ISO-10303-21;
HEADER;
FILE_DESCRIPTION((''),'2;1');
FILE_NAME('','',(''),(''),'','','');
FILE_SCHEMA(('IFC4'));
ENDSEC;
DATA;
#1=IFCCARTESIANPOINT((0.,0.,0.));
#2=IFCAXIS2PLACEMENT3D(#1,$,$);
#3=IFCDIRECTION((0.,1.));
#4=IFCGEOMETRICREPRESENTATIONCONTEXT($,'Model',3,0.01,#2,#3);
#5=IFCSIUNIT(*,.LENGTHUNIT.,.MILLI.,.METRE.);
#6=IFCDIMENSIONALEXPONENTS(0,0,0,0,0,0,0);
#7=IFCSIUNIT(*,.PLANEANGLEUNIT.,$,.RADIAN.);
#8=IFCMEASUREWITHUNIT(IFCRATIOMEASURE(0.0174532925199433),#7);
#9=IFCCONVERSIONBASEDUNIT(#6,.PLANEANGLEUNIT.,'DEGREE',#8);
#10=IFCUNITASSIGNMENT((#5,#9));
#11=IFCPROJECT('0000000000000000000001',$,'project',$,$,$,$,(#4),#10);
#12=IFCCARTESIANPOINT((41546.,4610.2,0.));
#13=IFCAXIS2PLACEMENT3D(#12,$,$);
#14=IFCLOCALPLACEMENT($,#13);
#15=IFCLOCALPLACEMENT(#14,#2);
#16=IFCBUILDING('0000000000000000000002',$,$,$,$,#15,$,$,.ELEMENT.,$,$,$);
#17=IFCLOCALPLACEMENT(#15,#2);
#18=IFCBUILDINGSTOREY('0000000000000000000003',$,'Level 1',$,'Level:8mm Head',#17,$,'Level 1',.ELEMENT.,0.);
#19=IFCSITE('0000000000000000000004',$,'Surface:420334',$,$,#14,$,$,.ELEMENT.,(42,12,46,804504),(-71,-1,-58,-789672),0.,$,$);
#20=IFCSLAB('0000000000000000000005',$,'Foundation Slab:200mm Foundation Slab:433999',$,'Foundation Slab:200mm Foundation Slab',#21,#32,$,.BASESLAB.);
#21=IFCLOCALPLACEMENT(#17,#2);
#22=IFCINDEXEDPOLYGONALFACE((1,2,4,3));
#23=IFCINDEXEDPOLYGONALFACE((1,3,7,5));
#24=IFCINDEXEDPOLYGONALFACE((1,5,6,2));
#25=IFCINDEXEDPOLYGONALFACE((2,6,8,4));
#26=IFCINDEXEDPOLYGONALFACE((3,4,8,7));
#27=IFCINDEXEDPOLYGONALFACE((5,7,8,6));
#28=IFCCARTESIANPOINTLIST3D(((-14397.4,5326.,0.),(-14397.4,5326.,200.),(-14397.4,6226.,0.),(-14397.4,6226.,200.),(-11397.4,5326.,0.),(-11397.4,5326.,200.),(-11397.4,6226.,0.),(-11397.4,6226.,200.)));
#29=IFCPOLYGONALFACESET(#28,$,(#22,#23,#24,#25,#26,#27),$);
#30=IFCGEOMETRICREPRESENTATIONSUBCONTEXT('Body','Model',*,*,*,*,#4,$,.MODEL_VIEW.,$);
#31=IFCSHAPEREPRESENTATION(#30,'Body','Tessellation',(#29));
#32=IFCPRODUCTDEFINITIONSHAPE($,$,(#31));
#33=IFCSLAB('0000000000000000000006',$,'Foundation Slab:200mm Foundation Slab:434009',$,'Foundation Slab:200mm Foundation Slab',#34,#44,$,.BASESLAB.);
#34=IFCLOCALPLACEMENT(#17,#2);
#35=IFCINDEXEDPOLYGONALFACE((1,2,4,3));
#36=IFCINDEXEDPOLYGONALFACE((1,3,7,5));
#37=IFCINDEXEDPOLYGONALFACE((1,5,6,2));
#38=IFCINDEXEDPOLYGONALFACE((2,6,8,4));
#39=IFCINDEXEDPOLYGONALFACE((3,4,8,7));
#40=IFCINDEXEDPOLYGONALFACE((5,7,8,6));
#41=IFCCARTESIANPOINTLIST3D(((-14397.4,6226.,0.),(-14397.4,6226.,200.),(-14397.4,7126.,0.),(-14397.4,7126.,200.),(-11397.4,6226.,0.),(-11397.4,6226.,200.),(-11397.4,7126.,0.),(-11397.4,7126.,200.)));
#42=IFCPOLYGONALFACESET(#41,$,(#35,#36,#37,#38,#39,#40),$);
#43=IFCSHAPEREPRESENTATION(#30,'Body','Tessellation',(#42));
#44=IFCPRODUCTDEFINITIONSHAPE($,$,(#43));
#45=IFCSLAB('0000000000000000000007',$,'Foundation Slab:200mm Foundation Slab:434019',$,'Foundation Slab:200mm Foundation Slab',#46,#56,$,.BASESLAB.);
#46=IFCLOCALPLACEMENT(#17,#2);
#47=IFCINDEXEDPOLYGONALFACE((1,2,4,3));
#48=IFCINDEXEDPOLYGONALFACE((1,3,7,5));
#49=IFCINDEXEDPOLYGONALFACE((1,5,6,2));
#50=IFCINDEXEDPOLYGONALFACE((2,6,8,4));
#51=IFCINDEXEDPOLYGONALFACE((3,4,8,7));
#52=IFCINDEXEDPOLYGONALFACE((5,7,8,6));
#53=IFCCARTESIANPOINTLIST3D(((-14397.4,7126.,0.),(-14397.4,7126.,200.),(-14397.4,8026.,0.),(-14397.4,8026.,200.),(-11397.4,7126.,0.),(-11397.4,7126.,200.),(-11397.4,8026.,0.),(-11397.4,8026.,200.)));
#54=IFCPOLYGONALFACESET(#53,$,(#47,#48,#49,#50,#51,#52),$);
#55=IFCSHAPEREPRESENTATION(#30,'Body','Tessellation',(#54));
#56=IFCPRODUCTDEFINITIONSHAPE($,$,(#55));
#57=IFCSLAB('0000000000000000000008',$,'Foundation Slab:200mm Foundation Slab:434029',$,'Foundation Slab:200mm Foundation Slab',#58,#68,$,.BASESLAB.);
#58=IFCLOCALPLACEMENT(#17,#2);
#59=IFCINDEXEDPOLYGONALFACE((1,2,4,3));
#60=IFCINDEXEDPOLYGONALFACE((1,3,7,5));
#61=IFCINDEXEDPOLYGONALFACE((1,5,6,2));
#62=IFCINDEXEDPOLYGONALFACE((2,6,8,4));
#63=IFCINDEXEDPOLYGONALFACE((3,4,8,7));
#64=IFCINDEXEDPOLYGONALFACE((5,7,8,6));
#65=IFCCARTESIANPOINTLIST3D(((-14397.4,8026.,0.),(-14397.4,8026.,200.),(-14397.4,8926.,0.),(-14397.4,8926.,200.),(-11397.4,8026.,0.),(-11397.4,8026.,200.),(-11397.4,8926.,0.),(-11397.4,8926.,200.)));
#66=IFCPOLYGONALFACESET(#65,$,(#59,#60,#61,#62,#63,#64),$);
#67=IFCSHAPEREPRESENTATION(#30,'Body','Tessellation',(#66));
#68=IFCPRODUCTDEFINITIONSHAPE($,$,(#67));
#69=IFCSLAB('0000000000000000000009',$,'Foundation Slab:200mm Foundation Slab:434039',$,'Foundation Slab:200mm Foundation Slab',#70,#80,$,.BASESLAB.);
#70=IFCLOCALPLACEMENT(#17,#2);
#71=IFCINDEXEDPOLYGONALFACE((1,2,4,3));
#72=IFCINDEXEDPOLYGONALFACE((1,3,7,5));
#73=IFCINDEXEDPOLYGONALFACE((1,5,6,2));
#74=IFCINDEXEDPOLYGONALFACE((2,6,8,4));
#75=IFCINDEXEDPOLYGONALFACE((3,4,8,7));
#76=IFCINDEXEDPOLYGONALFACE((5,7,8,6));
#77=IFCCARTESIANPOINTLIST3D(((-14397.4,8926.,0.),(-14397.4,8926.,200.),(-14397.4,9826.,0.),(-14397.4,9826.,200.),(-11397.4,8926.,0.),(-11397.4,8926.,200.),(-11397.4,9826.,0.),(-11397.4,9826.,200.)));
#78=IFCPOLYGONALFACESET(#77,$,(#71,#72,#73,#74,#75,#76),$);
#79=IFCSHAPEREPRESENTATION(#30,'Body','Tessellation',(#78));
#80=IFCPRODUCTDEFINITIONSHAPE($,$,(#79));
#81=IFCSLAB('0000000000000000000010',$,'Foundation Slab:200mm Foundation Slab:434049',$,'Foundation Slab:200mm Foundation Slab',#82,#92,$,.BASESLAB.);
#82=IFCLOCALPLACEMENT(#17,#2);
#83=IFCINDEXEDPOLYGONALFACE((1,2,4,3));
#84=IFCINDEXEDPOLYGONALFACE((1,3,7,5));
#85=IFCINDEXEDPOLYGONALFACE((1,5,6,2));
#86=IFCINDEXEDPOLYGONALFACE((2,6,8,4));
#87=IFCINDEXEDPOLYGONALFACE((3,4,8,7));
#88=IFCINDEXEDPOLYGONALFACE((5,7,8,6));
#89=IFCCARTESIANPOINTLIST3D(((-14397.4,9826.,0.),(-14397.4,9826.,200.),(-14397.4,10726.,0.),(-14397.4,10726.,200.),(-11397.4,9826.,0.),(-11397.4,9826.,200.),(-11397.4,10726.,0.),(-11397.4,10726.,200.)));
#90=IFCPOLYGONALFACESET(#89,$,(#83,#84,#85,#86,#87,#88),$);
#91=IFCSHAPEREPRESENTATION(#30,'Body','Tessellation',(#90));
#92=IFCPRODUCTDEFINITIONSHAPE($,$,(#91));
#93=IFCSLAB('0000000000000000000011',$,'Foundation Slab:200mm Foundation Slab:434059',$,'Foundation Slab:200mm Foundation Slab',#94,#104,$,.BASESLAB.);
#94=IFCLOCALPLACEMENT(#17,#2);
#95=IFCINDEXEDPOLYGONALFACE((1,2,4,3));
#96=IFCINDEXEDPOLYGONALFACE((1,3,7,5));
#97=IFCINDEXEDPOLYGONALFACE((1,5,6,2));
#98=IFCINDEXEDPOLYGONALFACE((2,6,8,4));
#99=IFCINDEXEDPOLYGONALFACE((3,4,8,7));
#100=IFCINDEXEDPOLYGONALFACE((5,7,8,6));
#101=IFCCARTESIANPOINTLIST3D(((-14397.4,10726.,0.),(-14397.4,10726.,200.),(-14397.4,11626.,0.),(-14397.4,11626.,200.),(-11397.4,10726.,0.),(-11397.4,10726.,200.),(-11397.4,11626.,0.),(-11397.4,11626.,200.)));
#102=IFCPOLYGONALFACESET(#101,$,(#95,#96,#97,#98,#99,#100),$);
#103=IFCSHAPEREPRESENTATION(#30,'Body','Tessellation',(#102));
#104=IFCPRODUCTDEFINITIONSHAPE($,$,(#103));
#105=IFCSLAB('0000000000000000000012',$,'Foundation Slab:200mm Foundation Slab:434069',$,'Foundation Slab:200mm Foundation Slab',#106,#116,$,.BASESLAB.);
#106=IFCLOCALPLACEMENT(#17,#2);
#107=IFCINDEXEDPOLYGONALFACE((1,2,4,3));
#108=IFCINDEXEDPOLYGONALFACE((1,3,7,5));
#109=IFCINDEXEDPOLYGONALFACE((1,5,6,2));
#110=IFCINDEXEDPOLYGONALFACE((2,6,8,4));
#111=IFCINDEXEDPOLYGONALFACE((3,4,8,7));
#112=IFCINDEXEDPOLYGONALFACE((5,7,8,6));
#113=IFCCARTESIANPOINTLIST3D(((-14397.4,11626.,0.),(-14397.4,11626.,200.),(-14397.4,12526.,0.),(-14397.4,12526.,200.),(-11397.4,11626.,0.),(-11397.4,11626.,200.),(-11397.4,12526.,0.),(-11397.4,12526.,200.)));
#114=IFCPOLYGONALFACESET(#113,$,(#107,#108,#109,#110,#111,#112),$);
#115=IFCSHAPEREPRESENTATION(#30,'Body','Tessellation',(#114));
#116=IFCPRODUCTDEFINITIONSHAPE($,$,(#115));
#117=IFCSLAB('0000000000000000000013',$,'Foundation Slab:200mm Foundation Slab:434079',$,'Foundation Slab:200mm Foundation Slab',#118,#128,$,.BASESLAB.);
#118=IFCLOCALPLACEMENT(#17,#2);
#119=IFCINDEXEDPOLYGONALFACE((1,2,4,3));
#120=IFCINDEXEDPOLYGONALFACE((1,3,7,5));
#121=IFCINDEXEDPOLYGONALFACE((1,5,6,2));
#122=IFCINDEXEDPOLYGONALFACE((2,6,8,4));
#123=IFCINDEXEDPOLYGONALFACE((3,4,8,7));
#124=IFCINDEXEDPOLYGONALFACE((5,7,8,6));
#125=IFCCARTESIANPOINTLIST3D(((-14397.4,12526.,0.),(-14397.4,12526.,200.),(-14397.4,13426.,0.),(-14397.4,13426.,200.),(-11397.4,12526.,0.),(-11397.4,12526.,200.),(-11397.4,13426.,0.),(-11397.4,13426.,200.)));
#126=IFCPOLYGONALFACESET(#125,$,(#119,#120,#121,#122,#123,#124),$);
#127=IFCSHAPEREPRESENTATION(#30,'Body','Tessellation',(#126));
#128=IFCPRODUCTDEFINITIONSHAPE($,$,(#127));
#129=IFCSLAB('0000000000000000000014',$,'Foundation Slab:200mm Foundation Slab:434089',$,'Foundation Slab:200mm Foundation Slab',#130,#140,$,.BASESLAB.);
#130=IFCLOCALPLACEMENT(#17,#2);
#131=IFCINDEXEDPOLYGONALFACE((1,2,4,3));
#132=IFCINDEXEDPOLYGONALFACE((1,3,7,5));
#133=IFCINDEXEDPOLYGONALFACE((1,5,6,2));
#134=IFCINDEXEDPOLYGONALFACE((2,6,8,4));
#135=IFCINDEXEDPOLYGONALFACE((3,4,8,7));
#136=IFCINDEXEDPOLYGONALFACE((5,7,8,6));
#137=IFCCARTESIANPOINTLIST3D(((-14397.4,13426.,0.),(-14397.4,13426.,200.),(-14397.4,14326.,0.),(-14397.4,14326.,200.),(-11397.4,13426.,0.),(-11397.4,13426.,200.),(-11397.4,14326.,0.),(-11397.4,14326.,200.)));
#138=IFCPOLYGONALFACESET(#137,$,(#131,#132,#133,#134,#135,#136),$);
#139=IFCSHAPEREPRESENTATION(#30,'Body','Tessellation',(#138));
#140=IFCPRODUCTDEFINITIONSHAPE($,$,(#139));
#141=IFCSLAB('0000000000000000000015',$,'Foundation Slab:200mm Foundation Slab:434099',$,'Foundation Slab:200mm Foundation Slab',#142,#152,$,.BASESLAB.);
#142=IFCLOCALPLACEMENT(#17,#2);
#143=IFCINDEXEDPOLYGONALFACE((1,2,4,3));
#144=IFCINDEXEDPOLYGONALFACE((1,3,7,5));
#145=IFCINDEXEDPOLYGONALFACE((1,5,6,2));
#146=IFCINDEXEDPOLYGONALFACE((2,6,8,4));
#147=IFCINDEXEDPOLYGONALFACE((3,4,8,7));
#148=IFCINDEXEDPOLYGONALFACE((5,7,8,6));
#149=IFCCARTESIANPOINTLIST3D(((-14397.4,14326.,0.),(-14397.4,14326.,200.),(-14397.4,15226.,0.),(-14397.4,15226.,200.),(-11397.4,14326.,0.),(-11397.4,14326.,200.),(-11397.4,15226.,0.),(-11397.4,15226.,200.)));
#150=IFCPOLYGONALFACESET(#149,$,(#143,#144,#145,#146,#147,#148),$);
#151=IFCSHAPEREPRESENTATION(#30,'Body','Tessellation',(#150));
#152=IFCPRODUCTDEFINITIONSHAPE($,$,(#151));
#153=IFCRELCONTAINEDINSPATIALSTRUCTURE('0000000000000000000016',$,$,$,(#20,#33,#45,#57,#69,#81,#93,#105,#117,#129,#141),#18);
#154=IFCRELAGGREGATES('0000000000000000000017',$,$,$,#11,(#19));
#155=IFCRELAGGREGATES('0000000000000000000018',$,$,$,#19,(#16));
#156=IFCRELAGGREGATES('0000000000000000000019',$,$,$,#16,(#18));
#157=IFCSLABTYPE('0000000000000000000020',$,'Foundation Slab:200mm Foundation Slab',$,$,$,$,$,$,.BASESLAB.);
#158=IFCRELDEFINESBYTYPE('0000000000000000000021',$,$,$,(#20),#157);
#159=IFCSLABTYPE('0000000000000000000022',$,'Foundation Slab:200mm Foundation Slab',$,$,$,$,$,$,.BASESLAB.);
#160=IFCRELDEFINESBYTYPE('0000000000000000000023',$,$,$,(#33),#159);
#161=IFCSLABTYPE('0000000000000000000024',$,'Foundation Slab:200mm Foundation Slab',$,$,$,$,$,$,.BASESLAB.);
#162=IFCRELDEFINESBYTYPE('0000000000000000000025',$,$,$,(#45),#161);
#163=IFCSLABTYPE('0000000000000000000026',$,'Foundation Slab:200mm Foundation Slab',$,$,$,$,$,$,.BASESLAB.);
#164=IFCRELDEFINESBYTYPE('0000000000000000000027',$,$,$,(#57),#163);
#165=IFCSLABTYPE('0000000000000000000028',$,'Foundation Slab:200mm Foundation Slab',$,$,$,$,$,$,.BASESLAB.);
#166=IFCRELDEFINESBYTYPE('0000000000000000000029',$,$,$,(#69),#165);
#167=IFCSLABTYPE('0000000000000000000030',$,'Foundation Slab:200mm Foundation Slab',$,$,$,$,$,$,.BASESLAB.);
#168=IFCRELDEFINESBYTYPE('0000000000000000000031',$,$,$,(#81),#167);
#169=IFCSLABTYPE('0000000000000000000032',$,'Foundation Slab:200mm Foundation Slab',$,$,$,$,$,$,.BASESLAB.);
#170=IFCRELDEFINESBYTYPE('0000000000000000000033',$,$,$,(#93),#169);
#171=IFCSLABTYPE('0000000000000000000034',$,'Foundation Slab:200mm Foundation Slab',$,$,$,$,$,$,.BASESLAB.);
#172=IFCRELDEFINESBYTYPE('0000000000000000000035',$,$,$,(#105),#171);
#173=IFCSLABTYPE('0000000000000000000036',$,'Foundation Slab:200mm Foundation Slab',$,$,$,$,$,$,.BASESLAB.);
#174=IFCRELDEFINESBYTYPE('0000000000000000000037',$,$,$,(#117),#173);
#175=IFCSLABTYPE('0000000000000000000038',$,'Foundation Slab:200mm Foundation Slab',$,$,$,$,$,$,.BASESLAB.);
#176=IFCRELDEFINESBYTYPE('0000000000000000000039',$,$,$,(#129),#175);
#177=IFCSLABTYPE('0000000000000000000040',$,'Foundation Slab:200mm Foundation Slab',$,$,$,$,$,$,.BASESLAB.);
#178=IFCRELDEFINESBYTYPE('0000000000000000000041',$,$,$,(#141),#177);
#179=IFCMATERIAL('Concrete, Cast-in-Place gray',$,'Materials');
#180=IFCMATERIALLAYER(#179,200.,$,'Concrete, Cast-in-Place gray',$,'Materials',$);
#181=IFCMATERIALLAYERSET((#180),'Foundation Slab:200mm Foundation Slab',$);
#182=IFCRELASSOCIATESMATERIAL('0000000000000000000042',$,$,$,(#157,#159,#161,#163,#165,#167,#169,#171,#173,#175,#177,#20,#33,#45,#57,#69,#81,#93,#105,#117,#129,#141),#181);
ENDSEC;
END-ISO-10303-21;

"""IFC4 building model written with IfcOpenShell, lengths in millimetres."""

from ifc_helpers import new_model, entity, si_unit, converted_unit, direction, frame, origin, origin_2d_with_axis, place, context, subcontext, project, spatial, rectangle, extrude, material, layer, layer_set, layer_usage, type_object, element, save


model = new_model("IFC4")

# Units and contexts
model_context = context("Model", 3, precision=0.01, world=origin(), true_north=direction((0.0, 1.0)))
body_context = subcontext(model_context, "Body", "Model", "MODEL_VIEW")
ifc_project = project(units=[si_unit("LENGTHUNIT", "METRE", prefix="MILLI"), converted_unit("PLANEANGLEUNIT", "DEGREE", entity("IfcRatioMeasure", 0.0174532925199433), si_unit("PLANEANGLEUNIT", "RADIAN"), dimensions=[0, 0, 0, 0, 0, 0, 0])], contexts=[model_context])

# Site, building, storey
site_placement = place(None, frame((41546.0, 4610.2, 0.0)))
site = spatial("IfcSite", under=ifc_project, at=site_placement, Name="Surface:420334", CompositionType="ELEMENT", RefLatitude=(42, 12, 46, 804504), RefLongitude=(-71, -1, -58, -789672), RefElevation=0.0)
building_placement = place(site_placement, origin())
building = spatial("IfcBuilding", under=site, at=building_placement, CompositionType="ELEMENT")
storey_placement = place(building_placement, origin())
storey = spatial("IfcBuildingStorey", under=building, at=storey_placement, Name="Level 1", ObjectType="Level:8mm Head", LongName="Level 1", CompositionType="ELEMENT", Elevation=0.0)

# Slabs
ifc_material_1 = material(Name="Concrete, Cast-in-Place gray", Category="Materials")
ifc_layer_1 = layer(ifc_material_1, 200.0, Name="Concrete, Cast-in-Place gray", Category="Materials")
ifc_layer_set_1 = layer_set([ifc_layer_1], Name="Foundation Slab:200mm Foundation Slab")
ifc_layer_usage_1 = layer_usage(ifc_layer_set_1, "AXIS3", "POSITIVE", 0.0)
slab_type_1 = type_object("IfcSlabType", Name="Foundation Slab:200mm Foundation Slab", PredefinedType="BASESLAB", material=ifc_layer_set_1)
slab_1_placement = place(storey_placement, origin())
element("IfcSlab", 1, at=slab_1_placement, inside=storey, type_object=slab_type_1, material=ifc_layer_usage_1, Name="Foundation Slab:200mm Foundation Slab:433999", ObjectType="Foundation Slab:200mm Foundation Slab", PredefinedType="BASESLAB", context=body_context, shape_type="SweptSolid", body=[
    extrude(rectangle(XDim=900.0, YDim=3000.0, at=origin_2d_with_axis()), frame((-12897.4, 5776.0, 200.0), z_axis=(0.0, 0.0, -1.0), x_axis=(0.0, 1.0, 0.0)), (0.0, 0.0, 1.0), 200.0),
])
ifc_layer_usage_2 = layer_usage(ifc_layer_set_1, "AXIS3", "POSITIVE", 0.0)
slab_type_2 = type_object("IfcSlabType", Name="Foundation Slab:200mm Foundation Slab", PredefinedType="BASESLAB", material=ifc_layer_set_1)
slab_2_placement = place(storey_placement, origin())
element("IfcSlab", 2, at=slab_2_placement, inside=storey, type_object=slab_type_2, material=ifc_layer_usage_2, Name="Foundation Slab:200mm Foundation Slab:434009", ObjectType="Foundation Slab:200mm Foundation Slab", PredefinedType="BASESLAB", context=body_context, shape_type="SweptSolid", body=[
    extrude(rectangle(XDim=900.0, YDim=3000.0, at=origin_2d_with_axis()), frame((-12897.4, 6676.0, 200.0), z_axis=(0.0, 0.0, -1.0), x_axis=(0.0, 1.0, 0.0)), (0.0, 0.0, 1.0), 200.0),
])
ifc_layer_usage_3 = layer_usage(ifc_layer_set_1, "AXIS3", "POSITIVE", 0.0)
slab_type_3 = type_object("IfcSlabType", Name="Foundation Slab:200mm Foundation Slab", PredefinedType="BASESLAB", material=ifc_layer_set_1)
slab_3_placement = place(storey_placement, origin())
element("IfcSlab", 3, at=slab_3_placement, inside=storey, type_object=slab_type_3, material=ifc_layer_usage_3, Name="Foundation Slab:200mm Foundation Slab:434019", ObjectType="Foundation Slab:200mm Foundation Slab", PredefinedType="BASESLAB", context=body_context, shape_type="SweptSolid", body=[
    extrude(rectangle(XDim=900.0, YDim=3000.0, at=origin_2d_with_axis()), frame((-12897.4, 7576.0, 200.0), z_axis=(0.0, 0.0, -1.0), x_axis=(0.0, 1.0, 0.0)), (0.0, 0.0, 1.0), 200.0),
])
ifc_layer_usage_4 = layer_usage(ifc_layer_set_1, "AXIS3", "POSITIVE", 0.0)
slab_type_4 = type_object("IfcSlabType", Name="Foundation Slab:200mm Foundation Slab", PredefinedType="BASESLAB", material=ifc_layer_set_1)
slab_4_placement = place(storey_placement, origin())
element("IfcSlab", 4, at=slab_4_placement, inside=storey, type_object=slab_type_4, material=ifc_layer_usage_4, Name="Foundation Slab:200mm Foundation Slab:434029", ObjectType="Foundation Slab:200mm Foundation Slab", PredefinedType="BASESLAB", context=body_context, shape_type="SweptSolid", body=[
    extrude(rectangle(XDim=900.0, YDim=3000.0, at=origin_2d_with_axis()), frame((-12897.4, 8476.0, 200.0), z_axis=(0.0, 0.0, -1.0), x_axis=(0.0, 1.0, 0.0)), (0.0, 0.0, 1.0), 200.0),
])
ifc_layer_usage_5 = layer_usage(ifc_layer_set_1, "AXIS3", "POSITIVE", 0.0)
slab_type_5 = type_object("IfcSlabType", Name="Foundation Slab:200mm Foundation Slab", PredefinedType="BASESLAB", material=ifc_layer_set_1)
slab_5_placement = place(storey_placement, origin())
element("IfcSlab", 5, at=slab_5_placement, inside=storey, type_object=slab_type_5, material=ifc_layer_usage_5, Name="Foundation Slab:200mm Foundation Slab:434039", ObjectType="Foundation Slab:200mm Foundation Slab", PredefinedType="BASESLAB", context=body_context, shape_type="SweptSolid", body=[
    extrude(rectangle(XDim=900.0, YDim=3000.0, at=origin_2d_with_axis()), frame((-12897.4, 9376.0, 200.0), z_axis=(0.0, 0.0, -1.0), x_axis=(0.0, 1.0, 0.0)), (0.0, 0.0, 1.0), 200.0),
])
ifc_layer_usage_6 = layer_usage(ifc_layer_set_1, "AXIS3", "POSITIVE", 0.0)
slab_type_6 = type_object("IfcSlabType", Name="Foundation Slab:200mm Foundation Slab", PredefinedType="BASESLAB", material=ifc_layer_set_1)
slab_6_placement = place(storey_placement, origin())
element("IfcSlab", 6, at=slab_6_placement, inside=storey, type_object=slab_type_6, material=ifc_layer_usage_6, Name="Foundation Slab:200mm Foundation Slab:434049", ObjectType="Foundation Slab:200mm Foundation Slab", PredefinedType="BASESLAB", context=body_context, shape_type="SweptSolid", body=[
    extrude(rectangle(XDim=900.0, YDim=3000.0, at=origin_2d_with_axis()), frame((-12897.4, 10276.0, 200.0), z_axis=(0.0, 0.0, -1.0), x_axis=(0.0, 1.0, 0.0)), (0.0, 0.0, 1.0), 200.0),
])
ifc_layer_usage_7 = layer_usage(ifc_layer_set_1, "AXIS3", "POSITIVE", 0.0)
slab_type_7 = type_object("IfcSlabType", Name="Foundation Slab:200mm Foundation Slab", PredefinedType="BASESLAB", material=ifc_layer_set_1)
slab_7_placement = place(storey_placement, origin())
element("IfcSlab", 7, at=slab_7_placement, inside=storey, type_object=slab_type_7, material=ifc_layer_usage_7, Name="Foundation Slab:200mm Foundation Slab:434059", ObjectType="Foundation Slab:200mm Foundation Slab", PredefinedType="BASESLAB", context=body_context, shape_type="SweptSolid", body=[
    extrude(rectangle(XDim=900.0, YDim=3000.0, at=origin_2d_with_axis()), frame((-12897.4, 11176.0, 200.0), z_axis=(0.0, 0.0, -1.0), x_axis=(0.0, 1.0, 0.0)), (0.0, 0.0, 1.0), 200.0),
])
ifc_layer_usage_8 = layer_usage(ifc_layer_set_1, "AXIS3", "POSITIVE", 0.0)
slab_type_8 = type_object("IfcSlabType", Name="Foundation Slab:200mm Foundation Slab", PredefinedType="BASESLAB", material=ifc_layer_set_1)
slab_8_placement = place(storey_placement, origin())
element("IfcSlab", 8, at=slab_8_placement, inside=storey, type_object=slab_type_8, material=ifc_layer_usage_8, Name="Foundation Slab:200mm Foundation Slab:434069", ObjectType="Foundation Slab:200mm Foundation Slab", PredefinedType="BASESLAB", context=body_context, shape_type="SweptSolid", body=[
    extrude(rectangle(XDim=900.0, YDim=3000.0, at=origin_2d_with_axis()), frame((-12897.4, 12076.0, 200.0), z_axis=(0.0, 0.0, -1.0), x_axis=(0.0, 1.0, 0.0)), (0.0, 0.0, 1.0), 200.0),
])
ifc_layer_usage_9 = layer_usage(ifc_layer_set_1, "AXIS3", "POSITIVE", 0.0)
slab_type_9 = type_object("IfcSlabType", Name="Foundation Slab:200mm Foundation Slab", PredefinedType="BASESLAB", material=ifc_layer_set_1)
slab_9_placement = place(storey_placement, origin())
element("IfcSlab", 9, at=slab_9_placement, inside=storey, type_object=slab_type_9, material=ifc_layer_usage_9, Name="Foundation Slab:200mm Foundation Slab:434079", ObjectType="Foundation Slab:200mm Foundation Slab", PredefinedType="BASESLAB", context=body_context, shape_type="SweptSolid", body=[
    extrude(rectangle(XDim=900.0, YDim=3000.0, at=origin_2d_with_axis()), frame((-12897.4, 12976.0, 200.0), z_axis=(0.0, 0.0, -1.0), x_axis=(0.0, 1.0, 0.0)), (0.0, 0.0, 1.0), 200.0),
])
ifc_layer_usage_10 = layer_usage(ifc_layer_set_1, "AXIS3", "POSITIVE", 0.0)
slab_type_10 = type_object("IfcSlabType", Name="Foundation Slab:200mm Foundation Slab", PredefinedType="BASESLAB", material=ifc_layer_set_1)
slab_10_placement = place(storey_placement, origin())
element("IfcSlab", 10, at=slab_10_placement, inside=storey, type_object=slab_type_10, material=ifc_layer_usage_10, Name="Foundation Slab:200mm Foundation Slab:434089", ObjectType="Foundation Slab:200mm Foundation Slab", PredefinedType="BASESLAB", context=body_context, shape_type="SweptSolid", body=[
    extrude(rectangle(XDim=900.0, YDim=3000.0, at=origin_2d_with_axis()), frame((-12897.4, 13876.0, 200.0), z_axis=(0.0, 0.0, -1.0), x_axis=(0.0, 1.0, 0.0)), (0.0, 0.0, 1.0), 200.0),
])
ifc_layer_usage_11 = layer_usage(ifc_layer_set_1, "AXIS3", "POSITIVE", 0.0)
slab_type_11 = type_object("IfcSlabType", Name="Foundation Slab:200mm Foundation Slab", PredefinedType="BASESLAB", material=ifc_layer_set_1)
slab_11_placement = place(storey_placement, origin())
element("IfcSlab", 11, at=slab_11_placement, inside=storey, type_object=slab_type_11, material=ifc_layer_usage_11, Name="Foundation Slab:200mm Foundation Slab:434099", ObjectType="Foundation Slab:200mm Foundation Slab", PredefinedType="BASESLAB", context=body_context, shape_type="SweptSolid", body=[
    extrude(rectangle(XDim=900.0, YDim=3000.0, at=origin_2d_with_axis()), frame((-12897.4, 14776.0, 200.0), z_axis=(0.0, 0.0, -1.0), x_axis=(0.0, 1.0, 0.0)), (0.0, 0.0, 1.0), 200.0),
])

save(model, "model.ifc")
